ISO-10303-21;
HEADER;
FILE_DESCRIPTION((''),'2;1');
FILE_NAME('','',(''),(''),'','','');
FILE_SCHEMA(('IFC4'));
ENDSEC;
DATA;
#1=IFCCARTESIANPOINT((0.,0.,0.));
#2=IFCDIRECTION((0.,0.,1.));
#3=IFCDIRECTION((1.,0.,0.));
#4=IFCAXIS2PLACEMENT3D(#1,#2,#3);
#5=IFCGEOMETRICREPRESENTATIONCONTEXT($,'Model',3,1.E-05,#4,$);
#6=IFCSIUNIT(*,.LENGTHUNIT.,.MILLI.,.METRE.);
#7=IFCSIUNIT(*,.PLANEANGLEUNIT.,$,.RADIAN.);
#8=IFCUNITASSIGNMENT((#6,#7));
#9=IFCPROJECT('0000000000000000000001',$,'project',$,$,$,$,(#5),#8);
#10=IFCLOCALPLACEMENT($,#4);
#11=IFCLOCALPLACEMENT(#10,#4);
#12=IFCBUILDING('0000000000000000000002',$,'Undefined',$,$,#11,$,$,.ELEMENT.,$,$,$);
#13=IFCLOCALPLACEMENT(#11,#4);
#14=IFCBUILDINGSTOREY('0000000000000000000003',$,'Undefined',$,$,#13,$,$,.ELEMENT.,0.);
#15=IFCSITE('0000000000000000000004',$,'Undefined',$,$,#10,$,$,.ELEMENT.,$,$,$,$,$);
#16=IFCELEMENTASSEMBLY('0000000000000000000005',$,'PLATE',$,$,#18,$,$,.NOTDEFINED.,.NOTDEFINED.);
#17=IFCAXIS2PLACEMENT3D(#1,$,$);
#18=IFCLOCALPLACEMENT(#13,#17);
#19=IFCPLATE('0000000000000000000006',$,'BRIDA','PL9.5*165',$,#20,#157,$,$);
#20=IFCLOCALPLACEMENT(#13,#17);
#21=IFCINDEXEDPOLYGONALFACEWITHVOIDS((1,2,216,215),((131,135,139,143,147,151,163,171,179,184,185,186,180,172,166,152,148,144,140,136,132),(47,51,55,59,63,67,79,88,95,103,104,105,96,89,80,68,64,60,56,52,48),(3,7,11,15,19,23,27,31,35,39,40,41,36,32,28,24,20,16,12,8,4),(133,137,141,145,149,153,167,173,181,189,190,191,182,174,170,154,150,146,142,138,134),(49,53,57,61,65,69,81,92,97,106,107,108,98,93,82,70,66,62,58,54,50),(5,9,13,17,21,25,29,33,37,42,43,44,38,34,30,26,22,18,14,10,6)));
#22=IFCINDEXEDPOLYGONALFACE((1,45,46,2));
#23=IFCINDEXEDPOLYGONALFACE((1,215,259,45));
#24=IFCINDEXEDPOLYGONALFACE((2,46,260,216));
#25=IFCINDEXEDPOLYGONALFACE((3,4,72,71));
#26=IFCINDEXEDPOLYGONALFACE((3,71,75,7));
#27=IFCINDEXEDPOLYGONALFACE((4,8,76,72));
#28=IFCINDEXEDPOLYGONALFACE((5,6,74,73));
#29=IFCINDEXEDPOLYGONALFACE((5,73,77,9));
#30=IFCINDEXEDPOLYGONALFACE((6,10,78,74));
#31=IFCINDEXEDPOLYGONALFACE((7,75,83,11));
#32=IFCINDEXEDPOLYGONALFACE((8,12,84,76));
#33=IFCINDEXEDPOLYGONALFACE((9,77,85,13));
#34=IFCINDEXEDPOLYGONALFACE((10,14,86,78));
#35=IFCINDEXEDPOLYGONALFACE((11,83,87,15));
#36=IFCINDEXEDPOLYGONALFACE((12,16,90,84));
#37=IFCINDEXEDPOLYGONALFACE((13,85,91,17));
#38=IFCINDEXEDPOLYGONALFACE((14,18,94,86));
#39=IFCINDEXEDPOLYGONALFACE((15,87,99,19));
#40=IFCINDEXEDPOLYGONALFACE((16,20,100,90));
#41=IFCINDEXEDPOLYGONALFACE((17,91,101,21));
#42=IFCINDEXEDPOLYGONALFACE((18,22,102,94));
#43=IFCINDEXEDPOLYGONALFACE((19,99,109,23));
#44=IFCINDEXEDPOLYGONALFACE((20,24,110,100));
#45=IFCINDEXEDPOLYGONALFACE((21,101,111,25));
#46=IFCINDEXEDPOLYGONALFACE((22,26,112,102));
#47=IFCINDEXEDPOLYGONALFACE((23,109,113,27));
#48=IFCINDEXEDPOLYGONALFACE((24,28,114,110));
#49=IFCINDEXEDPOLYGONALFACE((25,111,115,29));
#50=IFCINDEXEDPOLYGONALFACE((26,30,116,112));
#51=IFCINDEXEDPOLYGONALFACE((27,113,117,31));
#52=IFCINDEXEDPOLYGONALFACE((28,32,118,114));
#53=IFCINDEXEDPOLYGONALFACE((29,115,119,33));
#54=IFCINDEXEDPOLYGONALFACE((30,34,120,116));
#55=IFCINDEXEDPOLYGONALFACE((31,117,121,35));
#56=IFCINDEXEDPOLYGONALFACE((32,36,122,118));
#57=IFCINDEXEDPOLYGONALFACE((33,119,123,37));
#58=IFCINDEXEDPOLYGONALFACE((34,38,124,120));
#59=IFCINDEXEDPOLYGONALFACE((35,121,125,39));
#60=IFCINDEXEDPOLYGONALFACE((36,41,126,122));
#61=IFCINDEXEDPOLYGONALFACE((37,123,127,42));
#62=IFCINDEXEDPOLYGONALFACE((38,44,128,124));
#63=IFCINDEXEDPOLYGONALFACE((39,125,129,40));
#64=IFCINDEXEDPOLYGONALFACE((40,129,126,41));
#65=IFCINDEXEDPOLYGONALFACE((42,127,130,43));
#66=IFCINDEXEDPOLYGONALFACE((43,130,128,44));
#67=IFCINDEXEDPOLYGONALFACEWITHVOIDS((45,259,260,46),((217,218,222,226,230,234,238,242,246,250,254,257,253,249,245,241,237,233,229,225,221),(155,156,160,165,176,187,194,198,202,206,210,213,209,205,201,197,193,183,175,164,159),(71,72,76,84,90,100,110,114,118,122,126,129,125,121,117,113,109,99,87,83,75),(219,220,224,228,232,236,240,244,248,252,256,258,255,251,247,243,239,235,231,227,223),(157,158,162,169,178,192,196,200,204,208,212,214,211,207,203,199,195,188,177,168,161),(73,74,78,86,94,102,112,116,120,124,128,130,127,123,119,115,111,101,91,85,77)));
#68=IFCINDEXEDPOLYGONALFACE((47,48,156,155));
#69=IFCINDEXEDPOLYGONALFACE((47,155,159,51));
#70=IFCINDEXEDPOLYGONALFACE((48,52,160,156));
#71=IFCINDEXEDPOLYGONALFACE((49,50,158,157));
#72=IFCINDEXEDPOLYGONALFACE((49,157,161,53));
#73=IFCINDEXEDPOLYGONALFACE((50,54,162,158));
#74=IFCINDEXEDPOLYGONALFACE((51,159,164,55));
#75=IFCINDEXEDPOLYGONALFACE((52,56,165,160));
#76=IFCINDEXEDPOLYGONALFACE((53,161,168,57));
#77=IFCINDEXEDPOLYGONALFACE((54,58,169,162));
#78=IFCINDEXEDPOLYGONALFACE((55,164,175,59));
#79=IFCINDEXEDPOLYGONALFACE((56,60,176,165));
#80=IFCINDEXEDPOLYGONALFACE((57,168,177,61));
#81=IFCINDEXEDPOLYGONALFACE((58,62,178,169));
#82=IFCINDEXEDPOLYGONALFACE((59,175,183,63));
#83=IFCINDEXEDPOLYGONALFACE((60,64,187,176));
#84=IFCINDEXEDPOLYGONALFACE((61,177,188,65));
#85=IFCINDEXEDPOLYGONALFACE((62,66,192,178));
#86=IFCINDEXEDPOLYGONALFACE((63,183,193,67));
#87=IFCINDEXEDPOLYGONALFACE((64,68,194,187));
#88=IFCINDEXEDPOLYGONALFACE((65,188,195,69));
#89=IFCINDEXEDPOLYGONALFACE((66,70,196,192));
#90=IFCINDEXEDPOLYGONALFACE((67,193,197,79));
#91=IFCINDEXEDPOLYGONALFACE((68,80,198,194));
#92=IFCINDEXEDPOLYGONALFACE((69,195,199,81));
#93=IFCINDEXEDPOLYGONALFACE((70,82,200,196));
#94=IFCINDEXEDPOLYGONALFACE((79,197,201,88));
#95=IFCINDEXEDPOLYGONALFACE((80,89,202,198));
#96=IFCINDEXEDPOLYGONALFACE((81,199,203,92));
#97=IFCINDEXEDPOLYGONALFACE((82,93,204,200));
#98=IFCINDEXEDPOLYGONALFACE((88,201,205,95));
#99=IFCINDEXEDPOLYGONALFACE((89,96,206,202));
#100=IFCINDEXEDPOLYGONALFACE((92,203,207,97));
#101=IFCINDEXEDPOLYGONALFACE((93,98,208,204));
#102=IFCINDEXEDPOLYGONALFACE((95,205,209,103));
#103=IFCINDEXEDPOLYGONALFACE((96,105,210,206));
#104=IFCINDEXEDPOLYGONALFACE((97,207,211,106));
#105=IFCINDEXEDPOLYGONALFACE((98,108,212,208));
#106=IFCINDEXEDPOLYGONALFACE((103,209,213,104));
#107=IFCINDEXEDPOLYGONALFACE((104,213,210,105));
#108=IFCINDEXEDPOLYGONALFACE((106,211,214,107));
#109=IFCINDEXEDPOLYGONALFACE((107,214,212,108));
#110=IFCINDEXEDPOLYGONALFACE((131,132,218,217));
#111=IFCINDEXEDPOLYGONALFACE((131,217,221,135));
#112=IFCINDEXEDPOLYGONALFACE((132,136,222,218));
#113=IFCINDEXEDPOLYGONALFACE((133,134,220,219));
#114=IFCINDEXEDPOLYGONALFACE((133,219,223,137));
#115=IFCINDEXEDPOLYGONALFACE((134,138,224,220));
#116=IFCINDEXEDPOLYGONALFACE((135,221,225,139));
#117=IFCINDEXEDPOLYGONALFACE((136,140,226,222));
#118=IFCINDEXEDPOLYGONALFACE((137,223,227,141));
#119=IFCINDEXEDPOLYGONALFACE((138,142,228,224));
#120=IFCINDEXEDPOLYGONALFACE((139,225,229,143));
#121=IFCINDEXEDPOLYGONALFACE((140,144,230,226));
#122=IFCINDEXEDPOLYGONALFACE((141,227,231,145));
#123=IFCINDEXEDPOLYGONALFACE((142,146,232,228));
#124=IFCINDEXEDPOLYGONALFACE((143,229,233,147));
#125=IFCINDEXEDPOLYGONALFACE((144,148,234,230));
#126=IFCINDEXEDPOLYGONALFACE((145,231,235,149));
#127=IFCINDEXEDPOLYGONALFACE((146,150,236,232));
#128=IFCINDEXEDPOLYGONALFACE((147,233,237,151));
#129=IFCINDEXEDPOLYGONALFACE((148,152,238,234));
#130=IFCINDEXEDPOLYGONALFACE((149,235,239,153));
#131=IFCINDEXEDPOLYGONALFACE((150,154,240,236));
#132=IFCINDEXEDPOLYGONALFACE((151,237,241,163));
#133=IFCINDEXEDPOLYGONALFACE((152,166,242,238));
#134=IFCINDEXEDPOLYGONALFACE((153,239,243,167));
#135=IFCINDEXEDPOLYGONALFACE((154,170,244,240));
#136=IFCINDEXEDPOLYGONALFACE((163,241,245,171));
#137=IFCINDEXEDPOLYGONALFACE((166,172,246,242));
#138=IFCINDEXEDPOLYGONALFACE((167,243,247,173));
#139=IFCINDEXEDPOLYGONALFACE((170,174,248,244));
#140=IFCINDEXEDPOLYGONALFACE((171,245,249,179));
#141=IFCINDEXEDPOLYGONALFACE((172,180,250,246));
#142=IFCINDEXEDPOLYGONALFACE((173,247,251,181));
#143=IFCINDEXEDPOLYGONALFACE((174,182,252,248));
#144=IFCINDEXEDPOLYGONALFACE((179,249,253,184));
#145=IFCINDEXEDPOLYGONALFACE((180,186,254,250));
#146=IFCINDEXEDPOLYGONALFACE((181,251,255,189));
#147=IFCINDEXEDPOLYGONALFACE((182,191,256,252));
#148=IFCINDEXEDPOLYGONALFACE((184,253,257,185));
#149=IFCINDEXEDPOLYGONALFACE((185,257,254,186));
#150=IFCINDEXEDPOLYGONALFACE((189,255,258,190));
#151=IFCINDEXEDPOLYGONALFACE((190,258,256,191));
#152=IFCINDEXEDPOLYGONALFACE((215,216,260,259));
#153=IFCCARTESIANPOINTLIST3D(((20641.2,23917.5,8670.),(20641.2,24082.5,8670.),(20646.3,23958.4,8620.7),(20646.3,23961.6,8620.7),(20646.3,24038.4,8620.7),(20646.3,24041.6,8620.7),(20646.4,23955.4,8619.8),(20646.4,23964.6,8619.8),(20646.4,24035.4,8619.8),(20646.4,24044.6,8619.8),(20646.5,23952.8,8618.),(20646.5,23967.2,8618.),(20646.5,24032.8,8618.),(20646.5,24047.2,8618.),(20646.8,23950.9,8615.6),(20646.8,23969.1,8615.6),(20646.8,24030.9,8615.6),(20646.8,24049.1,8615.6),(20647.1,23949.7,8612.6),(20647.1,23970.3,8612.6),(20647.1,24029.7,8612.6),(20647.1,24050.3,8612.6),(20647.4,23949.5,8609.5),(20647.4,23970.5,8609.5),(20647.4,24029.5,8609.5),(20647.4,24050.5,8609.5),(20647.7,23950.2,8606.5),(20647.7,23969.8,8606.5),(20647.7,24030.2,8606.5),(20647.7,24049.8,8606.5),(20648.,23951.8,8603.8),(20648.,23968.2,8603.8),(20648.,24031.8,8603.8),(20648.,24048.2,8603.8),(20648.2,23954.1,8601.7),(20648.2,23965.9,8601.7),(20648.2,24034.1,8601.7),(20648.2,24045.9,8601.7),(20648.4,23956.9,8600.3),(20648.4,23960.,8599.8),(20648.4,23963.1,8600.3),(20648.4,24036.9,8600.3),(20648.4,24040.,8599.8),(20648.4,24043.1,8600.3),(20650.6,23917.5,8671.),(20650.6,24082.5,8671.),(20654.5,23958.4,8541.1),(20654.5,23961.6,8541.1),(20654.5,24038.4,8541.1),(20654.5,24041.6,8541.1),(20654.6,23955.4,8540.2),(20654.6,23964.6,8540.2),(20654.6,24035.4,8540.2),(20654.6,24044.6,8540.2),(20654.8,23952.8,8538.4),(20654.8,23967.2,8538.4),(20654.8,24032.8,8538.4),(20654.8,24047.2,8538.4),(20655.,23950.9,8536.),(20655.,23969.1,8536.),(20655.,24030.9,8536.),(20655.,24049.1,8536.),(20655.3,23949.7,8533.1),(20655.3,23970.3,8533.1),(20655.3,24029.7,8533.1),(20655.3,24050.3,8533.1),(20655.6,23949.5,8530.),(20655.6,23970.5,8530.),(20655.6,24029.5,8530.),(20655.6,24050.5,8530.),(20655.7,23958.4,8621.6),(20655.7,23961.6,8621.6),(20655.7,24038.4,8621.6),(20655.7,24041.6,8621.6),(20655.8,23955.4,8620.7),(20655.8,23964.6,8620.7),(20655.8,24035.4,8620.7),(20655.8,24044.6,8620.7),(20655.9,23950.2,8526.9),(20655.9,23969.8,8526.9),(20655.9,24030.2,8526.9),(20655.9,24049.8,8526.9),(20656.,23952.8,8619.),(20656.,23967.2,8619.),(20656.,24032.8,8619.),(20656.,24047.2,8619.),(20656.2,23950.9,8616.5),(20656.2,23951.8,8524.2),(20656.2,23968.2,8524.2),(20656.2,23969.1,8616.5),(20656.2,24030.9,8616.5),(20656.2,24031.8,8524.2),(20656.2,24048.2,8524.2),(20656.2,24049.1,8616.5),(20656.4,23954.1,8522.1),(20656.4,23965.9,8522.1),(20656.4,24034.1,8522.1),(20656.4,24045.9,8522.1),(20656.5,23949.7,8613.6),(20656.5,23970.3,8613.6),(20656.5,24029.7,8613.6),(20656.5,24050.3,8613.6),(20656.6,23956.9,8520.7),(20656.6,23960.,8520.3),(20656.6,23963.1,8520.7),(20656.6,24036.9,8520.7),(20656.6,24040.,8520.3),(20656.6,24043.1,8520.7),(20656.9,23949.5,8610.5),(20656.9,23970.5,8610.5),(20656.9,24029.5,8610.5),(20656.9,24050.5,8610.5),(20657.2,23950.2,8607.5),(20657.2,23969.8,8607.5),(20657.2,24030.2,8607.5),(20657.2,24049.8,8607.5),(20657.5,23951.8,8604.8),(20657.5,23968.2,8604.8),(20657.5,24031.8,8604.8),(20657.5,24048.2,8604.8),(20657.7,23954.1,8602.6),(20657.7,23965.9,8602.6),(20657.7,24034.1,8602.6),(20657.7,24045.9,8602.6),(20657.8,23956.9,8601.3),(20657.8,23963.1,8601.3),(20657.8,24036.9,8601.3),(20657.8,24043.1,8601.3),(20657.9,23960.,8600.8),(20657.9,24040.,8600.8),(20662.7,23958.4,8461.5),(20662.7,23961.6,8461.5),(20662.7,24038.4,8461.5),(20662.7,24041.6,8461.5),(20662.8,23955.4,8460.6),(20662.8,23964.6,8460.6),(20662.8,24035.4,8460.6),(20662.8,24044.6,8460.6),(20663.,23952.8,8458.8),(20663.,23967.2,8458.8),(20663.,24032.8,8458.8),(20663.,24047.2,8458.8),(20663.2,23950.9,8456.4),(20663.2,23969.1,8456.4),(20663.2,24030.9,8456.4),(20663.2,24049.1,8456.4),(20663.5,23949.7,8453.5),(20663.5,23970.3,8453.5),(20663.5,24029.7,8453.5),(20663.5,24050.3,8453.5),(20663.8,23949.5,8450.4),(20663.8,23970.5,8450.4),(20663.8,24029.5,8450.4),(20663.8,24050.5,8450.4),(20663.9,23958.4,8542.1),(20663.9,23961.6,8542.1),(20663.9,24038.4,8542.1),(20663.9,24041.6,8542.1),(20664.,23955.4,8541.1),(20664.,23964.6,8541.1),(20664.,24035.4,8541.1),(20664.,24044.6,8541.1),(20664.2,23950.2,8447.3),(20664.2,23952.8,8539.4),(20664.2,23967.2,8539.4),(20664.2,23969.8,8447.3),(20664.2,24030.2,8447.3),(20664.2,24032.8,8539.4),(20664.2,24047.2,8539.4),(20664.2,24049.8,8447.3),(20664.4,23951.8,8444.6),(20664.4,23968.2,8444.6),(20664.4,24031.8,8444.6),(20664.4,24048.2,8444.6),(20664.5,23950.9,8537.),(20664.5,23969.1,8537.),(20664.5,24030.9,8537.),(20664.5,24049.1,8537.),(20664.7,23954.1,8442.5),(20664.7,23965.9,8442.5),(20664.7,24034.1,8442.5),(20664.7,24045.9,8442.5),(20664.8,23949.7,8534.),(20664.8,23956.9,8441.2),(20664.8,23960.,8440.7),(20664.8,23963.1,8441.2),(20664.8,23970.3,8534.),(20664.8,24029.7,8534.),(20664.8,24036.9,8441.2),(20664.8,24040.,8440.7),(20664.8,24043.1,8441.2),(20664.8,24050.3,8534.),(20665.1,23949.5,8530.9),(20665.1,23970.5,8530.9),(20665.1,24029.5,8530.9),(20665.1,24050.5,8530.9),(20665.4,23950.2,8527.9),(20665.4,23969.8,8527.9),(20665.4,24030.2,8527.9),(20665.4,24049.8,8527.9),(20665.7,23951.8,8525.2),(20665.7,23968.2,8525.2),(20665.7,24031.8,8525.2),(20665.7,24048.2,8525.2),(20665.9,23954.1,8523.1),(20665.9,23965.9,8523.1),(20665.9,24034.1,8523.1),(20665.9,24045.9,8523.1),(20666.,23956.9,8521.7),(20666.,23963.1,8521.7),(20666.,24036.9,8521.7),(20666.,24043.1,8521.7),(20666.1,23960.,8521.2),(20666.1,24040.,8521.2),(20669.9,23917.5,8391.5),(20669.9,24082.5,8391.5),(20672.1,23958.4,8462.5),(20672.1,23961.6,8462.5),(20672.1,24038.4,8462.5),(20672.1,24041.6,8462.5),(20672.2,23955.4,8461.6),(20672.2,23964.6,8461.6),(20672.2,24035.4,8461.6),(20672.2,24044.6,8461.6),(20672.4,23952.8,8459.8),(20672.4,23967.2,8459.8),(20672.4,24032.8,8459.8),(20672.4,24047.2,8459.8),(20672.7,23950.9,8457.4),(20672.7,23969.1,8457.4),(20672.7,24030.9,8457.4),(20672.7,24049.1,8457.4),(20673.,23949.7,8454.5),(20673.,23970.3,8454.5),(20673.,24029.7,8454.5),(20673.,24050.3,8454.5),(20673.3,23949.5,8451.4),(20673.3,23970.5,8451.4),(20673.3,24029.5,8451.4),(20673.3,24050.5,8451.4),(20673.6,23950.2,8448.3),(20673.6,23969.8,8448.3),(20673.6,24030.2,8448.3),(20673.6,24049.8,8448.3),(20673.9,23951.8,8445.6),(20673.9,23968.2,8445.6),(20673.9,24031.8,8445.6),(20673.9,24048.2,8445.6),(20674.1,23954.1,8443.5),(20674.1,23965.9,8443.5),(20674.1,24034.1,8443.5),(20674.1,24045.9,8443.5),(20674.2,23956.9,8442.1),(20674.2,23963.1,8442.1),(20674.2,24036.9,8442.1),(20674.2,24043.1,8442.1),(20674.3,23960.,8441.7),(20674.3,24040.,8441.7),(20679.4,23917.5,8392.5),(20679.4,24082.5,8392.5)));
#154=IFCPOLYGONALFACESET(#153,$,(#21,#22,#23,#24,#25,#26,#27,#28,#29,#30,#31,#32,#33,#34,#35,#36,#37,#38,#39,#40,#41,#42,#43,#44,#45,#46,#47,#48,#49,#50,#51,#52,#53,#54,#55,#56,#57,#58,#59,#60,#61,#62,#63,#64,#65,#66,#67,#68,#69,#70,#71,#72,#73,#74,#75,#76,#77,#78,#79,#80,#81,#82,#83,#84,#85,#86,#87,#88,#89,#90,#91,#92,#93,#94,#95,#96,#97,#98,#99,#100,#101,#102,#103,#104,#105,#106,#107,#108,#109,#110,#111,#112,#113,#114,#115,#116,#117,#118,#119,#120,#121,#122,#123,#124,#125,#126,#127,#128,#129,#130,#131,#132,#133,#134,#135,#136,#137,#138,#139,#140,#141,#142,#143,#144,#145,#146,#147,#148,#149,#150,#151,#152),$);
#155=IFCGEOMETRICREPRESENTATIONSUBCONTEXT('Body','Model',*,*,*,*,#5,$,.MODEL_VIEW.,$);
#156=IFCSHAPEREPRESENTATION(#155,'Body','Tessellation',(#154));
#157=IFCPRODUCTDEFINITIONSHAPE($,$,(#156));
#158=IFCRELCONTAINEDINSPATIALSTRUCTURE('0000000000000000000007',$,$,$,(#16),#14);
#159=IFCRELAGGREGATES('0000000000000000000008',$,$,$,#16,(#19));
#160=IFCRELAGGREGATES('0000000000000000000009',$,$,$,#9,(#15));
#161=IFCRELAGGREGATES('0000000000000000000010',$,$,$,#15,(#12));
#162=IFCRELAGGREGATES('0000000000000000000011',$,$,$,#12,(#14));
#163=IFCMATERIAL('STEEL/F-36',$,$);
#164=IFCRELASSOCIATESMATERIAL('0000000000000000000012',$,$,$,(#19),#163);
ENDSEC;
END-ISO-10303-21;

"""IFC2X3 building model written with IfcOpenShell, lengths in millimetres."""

from ifc_helpers import new_model, si_unit, frame, origin_with_axes, origin_2d_with_axis, place, context, subcontext, project, spatial, polyline, circle, outline, extrude, source, transform, mapped, material, element, aggregate, save


model = new_model("IFC2X3")

# Units and contexts
model_context = context("Model", 3, precision=1e-05, world=origin_with_axes())
body_context = subcontext(model_context, "Body", "Model", "MODEL_VIEW")
ifc_project = project(units=[si_unit("LENGTHUNIT", "METRE", prefix="MILLI"), si_unit("PLANEANGLEUNIT", "RADIAN")], contexts=[model_context])

# Site, building, storey
site_placement = place(None, origin_with_axes())
site = spatial("IfcSite", under=ifc_project, at=site_placement, Name="Undefined", CompositionType="ELEMENT")
building_placement = place(site_placement, origin_with_axes())
building = spatial("IfcBuilding", under=site, at=building_placement, Name="Undefined", CompositionType="ELEMENT")
storey_placement = place(building_placement, origin_with_axes())
storey = spatial("IfcBuildingStorey", under=building, at=storey_placement, Name="Undefined", CompositionType="ELEMENT", Elevation=0.0)

# Shared definitions
ifc_material_1 = material(Name="STEEL/F-36")

# Element assembly
assembly_1_placement = place(storey_placement, origin_with_axes())
assembly_1 = element("IfcElementAssembly", 1, at=assembly_1_placement, inside=storey, Name="PLATE", AssemblyPlace="NOTDEFINED", PredefinedType="NOTDEFINED")

# Plate, opening
plate_1_placement = place(assembly_1_placement, frame((20645.9, 23917.5, 8670.5), z_axis=(0.994715, 0.0, 0.102675), x_axis=(0.102675, 0.0, -0.994715)))
plate_1 = element("IfcPlate", 2, at=plate_1_placement, material=ifc_material_1, Name="BRIDA", Description="PL9.5*165", context=body_context, shape_type="SweptSolid", body=[
    extrude(outline(polyline([(0.0, 0.0), (280.0, 0.0), (280.0, 165.0), (0.0, 165.0), (0.0, 0.0)])), frame((0.0, 0.0, -4.8), z_axis=(0.0, 0.0, 1.0), x_axis=(1.0, 0.0, 0.0)), (0.0, 0.0, 1.0), 9.5),
])
shared_shape_1 = source(origin_with_axes(), body_context, "Body", "SweptSolid", [
    extrude(circle(Radius=10.5, at=origin_2d_with_axis()), frame((0.0, 9.4, 0.0), z_axis=(0.0, 1.0, 0.0), x_axis=(1.0, 0.0, 0.0)), (0.0, 0.0, 1.0), 9.7),
])
opening_1_placement = place(assembly_1_placement, frame((20666.2, 24000.0, 8612.3), z_axis=(0.0, 1.0, 0.0), x_axis=(0.102675, 0.0, -0.994715)))
element("IfcOpeningElement", 3, at=opening_1_placement, cuts=plate_1, ObjectType="Opening", context=body_context, shape_type="MappedRepresentation", body=[
    mapped(shared_shape_1, transform((0.0, 0.0, -40.0))),
    mapped(shared_shape_1, transform((80.0, 0.0, -40.0))),
    mapped(shared_shape_1, transform((160.0, 0.0, -40.0))),
    mapped(shared_shape_1, transform((0.0, 0.0, 40.0))),
    mapped(shared_shape_1, transform((80.0, 0.0, 40.0))),
    mapped(shared_shape_1, transform((160.0, 0.0, 40.0))),
])
aggregate(assembly_1, [plate_1])

save(model, "model.ifc")
